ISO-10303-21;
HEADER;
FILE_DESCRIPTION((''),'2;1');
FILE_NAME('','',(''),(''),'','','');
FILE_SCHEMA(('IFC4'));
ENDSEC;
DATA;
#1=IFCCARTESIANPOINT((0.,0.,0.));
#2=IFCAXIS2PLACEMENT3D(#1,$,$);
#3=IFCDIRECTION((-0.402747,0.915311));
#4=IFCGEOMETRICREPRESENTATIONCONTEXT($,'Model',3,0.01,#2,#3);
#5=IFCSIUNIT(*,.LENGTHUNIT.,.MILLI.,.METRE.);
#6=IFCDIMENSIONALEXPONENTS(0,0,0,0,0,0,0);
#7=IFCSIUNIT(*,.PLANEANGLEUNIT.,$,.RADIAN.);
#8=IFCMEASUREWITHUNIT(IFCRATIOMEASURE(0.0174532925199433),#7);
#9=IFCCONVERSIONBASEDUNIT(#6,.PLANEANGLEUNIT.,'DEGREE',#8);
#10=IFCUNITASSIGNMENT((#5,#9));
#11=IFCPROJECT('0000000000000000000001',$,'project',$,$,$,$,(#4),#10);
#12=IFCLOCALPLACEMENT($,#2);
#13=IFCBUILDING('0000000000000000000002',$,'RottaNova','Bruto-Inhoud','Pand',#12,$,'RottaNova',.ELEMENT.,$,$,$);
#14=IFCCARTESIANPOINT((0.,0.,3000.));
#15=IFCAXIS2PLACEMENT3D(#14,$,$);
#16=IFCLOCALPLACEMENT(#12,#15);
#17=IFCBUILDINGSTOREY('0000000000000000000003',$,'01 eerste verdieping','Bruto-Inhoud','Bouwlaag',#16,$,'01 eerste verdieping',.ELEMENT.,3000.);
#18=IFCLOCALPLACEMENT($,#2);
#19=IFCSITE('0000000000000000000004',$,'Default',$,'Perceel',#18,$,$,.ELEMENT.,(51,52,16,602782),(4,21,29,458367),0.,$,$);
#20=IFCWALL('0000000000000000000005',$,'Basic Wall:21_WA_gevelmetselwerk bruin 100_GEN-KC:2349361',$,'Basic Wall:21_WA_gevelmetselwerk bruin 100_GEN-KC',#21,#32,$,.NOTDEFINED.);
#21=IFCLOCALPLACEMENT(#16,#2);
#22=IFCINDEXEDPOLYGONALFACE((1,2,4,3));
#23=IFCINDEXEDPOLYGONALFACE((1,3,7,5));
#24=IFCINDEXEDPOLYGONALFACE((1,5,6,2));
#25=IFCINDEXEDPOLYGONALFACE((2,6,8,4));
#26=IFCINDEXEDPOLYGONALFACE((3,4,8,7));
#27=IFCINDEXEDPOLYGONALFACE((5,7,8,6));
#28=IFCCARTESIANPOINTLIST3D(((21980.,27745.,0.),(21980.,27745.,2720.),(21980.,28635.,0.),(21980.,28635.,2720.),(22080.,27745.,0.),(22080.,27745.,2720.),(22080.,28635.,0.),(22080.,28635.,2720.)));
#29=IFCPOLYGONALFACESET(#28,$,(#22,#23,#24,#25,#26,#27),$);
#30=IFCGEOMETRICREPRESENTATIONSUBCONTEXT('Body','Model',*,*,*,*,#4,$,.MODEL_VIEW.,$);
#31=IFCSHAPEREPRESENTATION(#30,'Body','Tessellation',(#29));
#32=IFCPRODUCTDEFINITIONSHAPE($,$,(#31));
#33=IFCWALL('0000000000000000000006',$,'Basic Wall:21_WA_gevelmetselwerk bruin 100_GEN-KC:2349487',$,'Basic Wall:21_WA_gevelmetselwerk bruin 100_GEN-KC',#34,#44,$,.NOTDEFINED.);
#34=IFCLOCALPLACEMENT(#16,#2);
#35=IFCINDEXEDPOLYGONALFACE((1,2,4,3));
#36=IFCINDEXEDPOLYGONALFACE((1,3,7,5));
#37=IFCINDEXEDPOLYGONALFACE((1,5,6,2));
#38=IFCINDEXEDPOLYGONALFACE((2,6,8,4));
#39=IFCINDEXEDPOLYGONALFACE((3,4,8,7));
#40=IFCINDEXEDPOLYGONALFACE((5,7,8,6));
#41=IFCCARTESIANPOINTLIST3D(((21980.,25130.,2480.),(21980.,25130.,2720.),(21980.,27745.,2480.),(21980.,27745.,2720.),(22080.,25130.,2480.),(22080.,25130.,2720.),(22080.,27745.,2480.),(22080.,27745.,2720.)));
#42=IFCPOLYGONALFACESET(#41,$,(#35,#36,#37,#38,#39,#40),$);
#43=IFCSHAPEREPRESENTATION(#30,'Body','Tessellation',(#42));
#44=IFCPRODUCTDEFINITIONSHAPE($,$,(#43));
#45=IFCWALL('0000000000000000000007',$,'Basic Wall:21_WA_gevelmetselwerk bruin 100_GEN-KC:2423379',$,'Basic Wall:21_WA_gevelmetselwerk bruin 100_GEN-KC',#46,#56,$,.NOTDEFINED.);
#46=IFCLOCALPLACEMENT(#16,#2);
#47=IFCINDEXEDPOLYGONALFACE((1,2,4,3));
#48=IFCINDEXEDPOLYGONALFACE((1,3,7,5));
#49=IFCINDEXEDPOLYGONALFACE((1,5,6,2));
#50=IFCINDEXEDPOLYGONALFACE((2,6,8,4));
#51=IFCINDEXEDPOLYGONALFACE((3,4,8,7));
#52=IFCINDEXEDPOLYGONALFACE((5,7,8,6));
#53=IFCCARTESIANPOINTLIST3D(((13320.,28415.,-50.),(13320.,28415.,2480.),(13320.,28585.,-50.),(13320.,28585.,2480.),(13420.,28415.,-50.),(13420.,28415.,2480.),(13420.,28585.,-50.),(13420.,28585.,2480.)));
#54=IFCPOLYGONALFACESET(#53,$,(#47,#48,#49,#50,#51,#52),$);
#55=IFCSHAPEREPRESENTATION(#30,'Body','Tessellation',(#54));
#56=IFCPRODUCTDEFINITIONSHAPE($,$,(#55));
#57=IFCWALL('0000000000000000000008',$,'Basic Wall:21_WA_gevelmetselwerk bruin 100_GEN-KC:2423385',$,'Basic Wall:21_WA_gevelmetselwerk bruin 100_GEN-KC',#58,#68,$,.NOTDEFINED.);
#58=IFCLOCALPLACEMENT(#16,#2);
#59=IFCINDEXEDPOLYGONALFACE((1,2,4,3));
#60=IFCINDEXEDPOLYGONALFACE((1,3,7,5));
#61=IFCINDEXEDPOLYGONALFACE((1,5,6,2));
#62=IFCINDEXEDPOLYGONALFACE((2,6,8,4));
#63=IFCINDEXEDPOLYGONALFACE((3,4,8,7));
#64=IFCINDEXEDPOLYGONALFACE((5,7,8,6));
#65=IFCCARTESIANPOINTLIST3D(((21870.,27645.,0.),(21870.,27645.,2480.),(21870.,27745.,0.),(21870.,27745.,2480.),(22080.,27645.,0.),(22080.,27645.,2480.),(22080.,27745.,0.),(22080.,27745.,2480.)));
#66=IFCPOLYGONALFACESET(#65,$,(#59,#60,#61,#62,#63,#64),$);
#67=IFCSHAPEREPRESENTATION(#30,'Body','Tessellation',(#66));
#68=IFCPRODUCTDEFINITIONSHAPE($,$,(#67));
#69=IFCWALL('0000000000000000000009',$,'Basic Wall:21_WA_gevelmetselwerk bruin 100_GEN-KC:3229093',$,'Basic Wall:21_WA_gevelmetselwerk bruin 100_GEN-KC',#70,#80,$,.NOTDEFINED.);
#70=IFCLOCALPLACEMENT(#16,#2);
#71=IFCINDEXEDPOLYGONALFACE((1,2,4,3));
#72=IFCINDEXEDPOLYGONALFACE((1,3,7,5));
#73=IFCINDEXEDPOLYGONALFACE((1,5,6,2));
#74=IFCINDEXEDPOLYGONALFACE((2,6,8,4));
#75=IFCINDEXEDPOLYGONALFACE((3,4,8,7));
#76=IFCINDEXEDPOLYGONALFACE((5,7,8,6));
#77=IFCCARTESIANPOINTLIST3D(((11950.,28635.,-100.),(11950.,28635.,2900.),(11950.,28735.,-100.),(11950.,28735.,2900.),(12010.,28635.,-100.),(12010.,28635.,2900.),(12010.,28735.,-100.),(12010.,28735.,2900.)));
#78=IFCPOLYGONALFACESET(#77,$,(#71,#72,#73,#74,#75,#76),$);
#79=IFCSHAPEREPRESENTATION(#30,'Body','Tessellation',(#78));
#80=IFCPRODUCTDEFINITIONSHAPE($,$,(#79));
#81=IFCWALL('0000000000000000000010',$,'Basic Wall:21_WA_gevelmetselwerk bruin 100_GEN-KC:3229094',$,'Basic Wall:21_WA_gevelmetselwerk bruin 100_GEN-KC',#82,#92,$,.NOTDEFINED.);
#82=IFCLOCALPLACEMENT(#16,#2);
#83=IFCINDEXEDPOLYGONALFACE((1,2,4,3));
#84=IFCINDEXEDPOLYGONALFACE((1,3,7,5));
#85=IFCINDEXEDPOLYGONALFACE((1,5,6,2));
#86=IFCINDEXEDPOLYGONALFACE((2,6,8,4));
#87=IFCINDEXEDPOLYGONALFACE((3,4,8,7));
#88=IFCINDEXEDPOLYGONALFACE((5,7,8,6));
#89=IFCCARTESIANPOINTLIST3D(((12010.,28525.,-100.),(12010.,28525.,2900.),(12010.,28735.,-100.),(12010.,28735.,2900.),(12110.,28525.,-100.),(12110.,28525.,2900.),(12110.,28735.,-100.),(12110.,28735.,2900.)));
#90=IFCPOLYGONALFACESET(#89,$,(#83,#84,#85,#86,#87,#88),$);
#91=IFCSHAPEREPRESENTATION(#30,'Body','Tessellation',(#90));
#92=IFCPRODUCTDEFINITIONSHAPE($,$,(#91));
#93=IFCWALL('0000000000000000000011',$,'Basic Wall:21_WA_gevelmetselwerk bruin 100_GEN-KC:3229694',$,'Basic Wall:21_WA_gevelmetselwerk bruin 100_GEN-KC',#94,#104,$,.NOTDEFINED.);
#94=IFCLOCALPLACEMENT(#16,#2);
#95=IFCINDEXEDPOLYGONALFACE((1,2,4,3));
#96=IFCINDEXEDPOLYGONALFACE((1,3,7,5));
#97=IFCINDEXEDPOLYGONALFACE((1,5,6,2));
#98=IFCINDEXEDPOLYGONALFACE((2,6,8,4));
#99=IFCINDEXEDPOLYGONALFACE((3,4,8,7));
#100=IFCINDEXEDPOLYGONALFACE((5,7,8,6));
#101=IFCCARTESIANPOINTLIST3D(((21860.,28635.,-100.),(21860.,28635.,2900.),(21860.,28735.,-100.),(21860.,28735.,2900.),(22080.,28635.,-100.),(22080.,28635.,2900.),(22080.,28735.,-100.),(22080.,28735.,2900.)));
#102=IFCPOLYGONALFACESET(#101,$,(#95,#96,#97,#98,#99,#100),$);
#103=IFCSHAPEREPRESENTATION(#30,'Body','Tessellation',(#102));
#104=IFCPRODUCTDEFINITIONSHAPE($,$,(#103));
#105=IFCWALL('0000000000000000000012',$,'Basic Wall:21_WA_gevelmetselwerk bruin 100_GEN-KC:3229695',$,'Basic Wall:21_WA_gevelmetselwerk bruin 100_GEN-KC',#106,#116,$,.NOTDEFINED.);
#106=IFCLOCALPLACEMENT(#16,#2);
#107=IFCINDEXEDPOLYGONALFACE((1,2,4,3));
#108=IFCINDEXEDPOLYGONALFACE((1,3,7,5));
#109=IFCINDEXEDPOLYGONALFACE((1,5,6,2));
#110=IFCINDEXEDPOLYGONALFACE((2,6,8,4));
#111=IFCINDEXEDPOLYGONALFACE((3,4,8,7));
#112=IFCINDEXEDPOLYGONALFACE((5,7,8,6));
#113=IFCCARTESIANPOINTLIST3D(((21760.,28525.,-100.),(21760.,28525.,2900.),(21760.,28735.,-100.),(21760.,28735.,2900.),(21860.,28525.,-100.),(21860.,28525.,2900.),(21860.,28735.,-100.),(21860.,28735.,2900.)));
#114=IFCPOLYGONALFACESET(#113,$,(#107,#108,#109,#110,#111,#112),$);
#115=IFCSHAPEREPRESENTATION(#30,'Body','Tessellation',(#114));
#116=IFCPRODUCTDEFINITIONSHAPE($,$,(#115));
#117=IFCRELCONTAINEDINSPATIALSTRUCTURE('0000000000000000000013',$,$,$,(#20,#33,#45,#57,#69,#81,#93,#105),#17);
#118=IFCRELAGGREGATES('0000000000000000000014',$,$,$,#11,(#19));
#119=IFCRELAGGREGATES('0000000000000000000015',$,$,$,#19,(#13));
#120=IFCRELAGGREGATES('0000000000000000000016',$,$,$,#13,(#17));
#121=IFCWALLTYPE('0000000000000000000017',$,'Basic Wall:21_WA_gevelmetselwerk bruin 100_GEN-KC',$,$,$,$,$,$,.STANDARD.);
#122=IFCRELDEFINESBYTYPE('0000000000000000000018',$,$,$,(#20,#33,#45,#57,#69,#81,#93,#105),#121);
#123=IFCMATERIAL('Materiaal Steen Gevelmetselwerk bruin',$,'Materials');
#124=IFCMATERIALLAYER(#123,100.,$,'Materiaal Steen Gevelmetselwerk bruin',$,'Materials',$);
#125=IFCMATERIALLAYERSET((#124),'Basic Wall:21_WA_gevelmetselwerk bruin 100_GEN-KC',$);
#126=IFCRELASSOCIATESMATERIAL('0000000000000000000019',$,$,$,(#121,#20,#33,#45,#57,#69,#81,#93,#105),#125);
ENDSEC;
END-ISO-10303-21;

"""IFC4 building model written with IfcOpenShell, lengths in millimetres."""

from ifc_helpers import new_model, entity, si_unit, converted_unit, direction, frame, frame_2d, origin, place, context, subcontext, project, spatial, rectangle, extrude, material, layer, layer_set, type_object, element, save


model = new_model("IFC4")

# Units and contexts
model_context = context("Model", 3, precision=0.01, world=origin(), true_north=direction((-0.402747, 0.915311)))
body_context = subcontext(model_context, "Body", "Model", "MODEL_VIEW")
ifc_project = project(units=[si_unit("LENGTHUNIT", "METRE", prefix="MILLI"), converted_unit("PLANEANGLEUNIT", "DEGREE", entity("IfcRatioMeasure", 0.0174532925199433), si_unit("PLANEANGLEUNIT", "RADIAN"), dimensions=[0, 0, 0, 0, 0, 0, 0])], contexts=[model_context])

# Site, building, storey
site_placement = place(None, origin())
site = spatial("IfcSite", under=ifc_project, at=site_placement, Name="Default", ObjectType="Perceel", CompositionType="ELEMENT", RefLatitude=(51, 52, 16, 602782), RefLongitude=(4, 21, 29, 458367), RefElevation=0.0)
building_placement = place(None, origin())
building = spatial("IfcBuilding", under=site, at=building_placement, Name="RottaNova", Description="Bruto-Inhoud", ObjectType="Pand", LongName="RottaNova", CompositionType="ELEMENT")
storey_placement = place(building_placement, frame((0.0, 0.0, 3000.0)))
storey = spatial("IfcBuildingStorey", under=building, at=storey_placement, Name="01 eerste verdieping", Description="Bruto-Inhoud", ObjectType="Bouwlaag", LongName="01 eerste verdieping", CompositionType="ELEMENT", Elevation=3000.0)

# Walls
ifc_material_1 = material(Name="Materiaal Steen Gevelmetselwerk bruin", Category="Materials")
ifc_layer_1 = layer(ifc_material_1, 100.0, Name="Materiaal Steen Gevelmetselwerk bruin", Category="Materials")
ifc_layer_set_1 = layer_set([ifc_layer_1], Name="Basic Wall:21_WA_gevelmetselwerk bruin 100_GEN-KC")
wall_type_1 = type_object("IfcWallType", Name="Basic Wall:21_WA_gevelmetselwerk bruin 100_GEN-KC", PredefinedType="STANDARD", material=ifc_layer_set_1)
wall_1_placement = place(storey_placement, frame((22030.0, 27745.0, 0.0), z_axis=(0.0, 0.0, 1.0), x_axis=(0.0, 1.0, 0.0)))
element("IfcWall", 1, at=wall_1_placement, inside=storey, type_object=wall_type_1, material=ifc_layer_set_1, Name="Basic Wall:21_WA_gevelmetselwerk bruin 100_GEN-KC:2349361", ObjectType="Basic Wall:21_WA_gevelmetselwerk bruin 100_GEN-KC", PredefinedType="NOTDEFINED", context=body_context, shape_type="SweptSolid", body=[
    extrude(rectangle(XDim=890.0, YDim=100.0, at=frame_2d((445.0, 0.0), x_axis=(-1.0, 0.0))), origin(), (0.0, 0.0, 1.0), 2720.0),
])
wall_2_placement = place(storey_placement, frame((22030.0, 25130.0, 2480.0), z_axis=(0.0, 0.0, 1.0), x_axis=(0.0, 1.0, 0.0)))
element("IfcWall", 2, at=wall_2_placement, inside=storey, type_object=wall_type_1, material=ifc_layer_set_1, Name="Basic Wall:21_WA_gevelmetselwerk bruin 100_GEN-KC:2349487", ObjectType="Basic Wall:21_WA_gevelmetselwerk bruin 100_GEN-KC", PredefinedType="NOTDEFINED", context=body_context, shape_type="SweptSolid", body=[
    extrude(rectangle(XDim=2615.0, YDim=100.0, at=frame_2d((1307.5, 0.0), x_axis=(-1.0, 0.0))), origin(), (0.0, 0.0, 1.0), 240.0),
])
wall_3_placement = place(storey_placement, frame((13370.0, 28415.0, -50.0), z_axis=(0.0, 0.0, 1.0), x_axis=(0.0, 1.0, 0.0)))
element("IfcWall", 3, at=wall_3_placement, inside=storey, type_object=wall_type_1, material=ifc_layer_set_1, Name="Basic Wall:21_WA_gevelmetselwerk bruin 100_GEN-KC:2423379", ObjectType="Basic Wall:21_WA_gevelmetselwerk bruin 100_GEN-KC", PredefinedType="NOTDEFINED", context=body_context, shape_type="SweptSolid", body=[
    extrude(rectangle(XDim=170.0, YDim=100.0, at=frame_2d((85.0, 0.0), x_axis=(-1.0, 0.0))), origin(), (0.0, 0.0, 1.0), 2530.0),
])
wall_4_placement = place(storey_placement, frame((21870.0, 27695.0, 0.0)))
element("IfcWall", 4, at=wall_4_placement, inside=storey, type_object=wall_type_1, material=ifc_layer_set_1, Name="Basic Wall:21_WA_gevelmetselwerk bruin 100_GEN-KC:2423385", ObjectType="Basic Wall:21_WA_gevelmetselwerk bruin 100_GEN-KC", PredefinedType="NOTDEFINED", context=body_context, shape_type="SweptSolid", body=[
    extrude(rectangle(XDim=210.0, YDim=100.0, at=frame_2d((105.0, 0.0), x_axis=(-1.0, 0.0))), origin(), (0.0, 0.0, 1.0), 2480.0),
])
wall_5_placement = place(storey_placement, frame((12010.0, 28685.0, -100.0), z_axis=(0.0, 0.0, 1.0), x_axis=(-1.0, 0.0, 0.0)))
element("IfcWall", 5, at=wall_5_placement, inside=storey, type_object=wall_type_1, material=ifc_layer_set_1, Name="Basic Wall:21_WA_gevelmetselwerk bruin 100_GEN-KC:3229093", ObjectType="Basic Wall:21_WA_gevelmetselwerk bruin 100_GEN-KC", PredefinedType="NOTDEFINED", context=body_context, shape_type="SweptSolid", body=[
    extrude(rectangle(XDim=60.0, YDim=100.0, at=frame_2d((30.0, 0.0), x_axis=(-1.0, 0.0))), origin(), (0.0, 0.0, 1.0), 3000.0),
])
wall_6_placement = place(storey_placement, frame((12060.0, 28735.0, -100.0), z_axis=(0.0, 0.0, 1.0), x_axis=(0.0, -1.0, 0.0)))
element("IfcWall", 6, at=wall_6_placement, inside=storey, type_object=wall_type_1, material=ifc_layer_set_1, Name="Basic Wall:21_WA_gevelmetselwerk bruin 100_GEN-KC:3229094", ObjectType="Basic Wall:21_WA_gevelmetselwerk bruin 100_GEN-KC", PredefinedType="NOTDEFINED", context=body_context, shape_type="SweptSolid", body=[
    extrude(rectangle(XDim=210.0, YDim=100.0, at=frame_2d((105.0, 0.0), x_axis=(-1.0, 0.0))), origin(), (0.0, 0.0, 1.0), 3000.0),
])
wall_7_placement = place(storey_placement, frame((21860.0, 28685.0, -100.0)))
element("IfcWall", 7, at=wall_7_placement, inside=storey, type_object=wall_type_1, material=ifc_layer_set_1, Name="Basic Wall:21_WA_gevelmetselwerk bruin 100_GEN-KC:3229694", ObjectType="Basic Wall:21_WA_gevelmetselwerk bruin 100_GEN-KC", PredefinedType="NOTDEFINED", context=body_context, shape_type="SweptSolid", body=[
    extrude(rectangle(XDim=220.0, YDim=100.0, at=frame_2d((110.0, 0.0), x_axis=(-1.0, 0.0))), origin(), (0.0, 0.0, 1.0), 3000.0),
])
wall_8_placement = place(storey_placement, frame((21810.0, 28735.0, -100.0), z_axis=(0.0, 0.0, 1.0), x_axis=(0.0, -1.0, 0.0)))
element("IfcWall", 8, at=wall_8_placement, inside=storey, type_object=wall_type_1, material=ifc_layer_set_1, Name="Basic Wall:21_WA_gevelmetselwerk bruin 100_GEN-KC:3229695", ObjectType="Basic Wall:21_WA_gevelmetselwerk bruin 100_GEN-KC", PredefinedType="NOTDEFINED", context=body_context, shape_type="SweptSolid", body=[
    extrude(rectangle(XDim=210.0, YDim=100.0, at=frame_2d((105.0, 0.0), x_axis=(-1.0, 0.0))), origin(), (0.0, 0.0, 1.0), 3000.0),
])

save(model, "model.ifc")
